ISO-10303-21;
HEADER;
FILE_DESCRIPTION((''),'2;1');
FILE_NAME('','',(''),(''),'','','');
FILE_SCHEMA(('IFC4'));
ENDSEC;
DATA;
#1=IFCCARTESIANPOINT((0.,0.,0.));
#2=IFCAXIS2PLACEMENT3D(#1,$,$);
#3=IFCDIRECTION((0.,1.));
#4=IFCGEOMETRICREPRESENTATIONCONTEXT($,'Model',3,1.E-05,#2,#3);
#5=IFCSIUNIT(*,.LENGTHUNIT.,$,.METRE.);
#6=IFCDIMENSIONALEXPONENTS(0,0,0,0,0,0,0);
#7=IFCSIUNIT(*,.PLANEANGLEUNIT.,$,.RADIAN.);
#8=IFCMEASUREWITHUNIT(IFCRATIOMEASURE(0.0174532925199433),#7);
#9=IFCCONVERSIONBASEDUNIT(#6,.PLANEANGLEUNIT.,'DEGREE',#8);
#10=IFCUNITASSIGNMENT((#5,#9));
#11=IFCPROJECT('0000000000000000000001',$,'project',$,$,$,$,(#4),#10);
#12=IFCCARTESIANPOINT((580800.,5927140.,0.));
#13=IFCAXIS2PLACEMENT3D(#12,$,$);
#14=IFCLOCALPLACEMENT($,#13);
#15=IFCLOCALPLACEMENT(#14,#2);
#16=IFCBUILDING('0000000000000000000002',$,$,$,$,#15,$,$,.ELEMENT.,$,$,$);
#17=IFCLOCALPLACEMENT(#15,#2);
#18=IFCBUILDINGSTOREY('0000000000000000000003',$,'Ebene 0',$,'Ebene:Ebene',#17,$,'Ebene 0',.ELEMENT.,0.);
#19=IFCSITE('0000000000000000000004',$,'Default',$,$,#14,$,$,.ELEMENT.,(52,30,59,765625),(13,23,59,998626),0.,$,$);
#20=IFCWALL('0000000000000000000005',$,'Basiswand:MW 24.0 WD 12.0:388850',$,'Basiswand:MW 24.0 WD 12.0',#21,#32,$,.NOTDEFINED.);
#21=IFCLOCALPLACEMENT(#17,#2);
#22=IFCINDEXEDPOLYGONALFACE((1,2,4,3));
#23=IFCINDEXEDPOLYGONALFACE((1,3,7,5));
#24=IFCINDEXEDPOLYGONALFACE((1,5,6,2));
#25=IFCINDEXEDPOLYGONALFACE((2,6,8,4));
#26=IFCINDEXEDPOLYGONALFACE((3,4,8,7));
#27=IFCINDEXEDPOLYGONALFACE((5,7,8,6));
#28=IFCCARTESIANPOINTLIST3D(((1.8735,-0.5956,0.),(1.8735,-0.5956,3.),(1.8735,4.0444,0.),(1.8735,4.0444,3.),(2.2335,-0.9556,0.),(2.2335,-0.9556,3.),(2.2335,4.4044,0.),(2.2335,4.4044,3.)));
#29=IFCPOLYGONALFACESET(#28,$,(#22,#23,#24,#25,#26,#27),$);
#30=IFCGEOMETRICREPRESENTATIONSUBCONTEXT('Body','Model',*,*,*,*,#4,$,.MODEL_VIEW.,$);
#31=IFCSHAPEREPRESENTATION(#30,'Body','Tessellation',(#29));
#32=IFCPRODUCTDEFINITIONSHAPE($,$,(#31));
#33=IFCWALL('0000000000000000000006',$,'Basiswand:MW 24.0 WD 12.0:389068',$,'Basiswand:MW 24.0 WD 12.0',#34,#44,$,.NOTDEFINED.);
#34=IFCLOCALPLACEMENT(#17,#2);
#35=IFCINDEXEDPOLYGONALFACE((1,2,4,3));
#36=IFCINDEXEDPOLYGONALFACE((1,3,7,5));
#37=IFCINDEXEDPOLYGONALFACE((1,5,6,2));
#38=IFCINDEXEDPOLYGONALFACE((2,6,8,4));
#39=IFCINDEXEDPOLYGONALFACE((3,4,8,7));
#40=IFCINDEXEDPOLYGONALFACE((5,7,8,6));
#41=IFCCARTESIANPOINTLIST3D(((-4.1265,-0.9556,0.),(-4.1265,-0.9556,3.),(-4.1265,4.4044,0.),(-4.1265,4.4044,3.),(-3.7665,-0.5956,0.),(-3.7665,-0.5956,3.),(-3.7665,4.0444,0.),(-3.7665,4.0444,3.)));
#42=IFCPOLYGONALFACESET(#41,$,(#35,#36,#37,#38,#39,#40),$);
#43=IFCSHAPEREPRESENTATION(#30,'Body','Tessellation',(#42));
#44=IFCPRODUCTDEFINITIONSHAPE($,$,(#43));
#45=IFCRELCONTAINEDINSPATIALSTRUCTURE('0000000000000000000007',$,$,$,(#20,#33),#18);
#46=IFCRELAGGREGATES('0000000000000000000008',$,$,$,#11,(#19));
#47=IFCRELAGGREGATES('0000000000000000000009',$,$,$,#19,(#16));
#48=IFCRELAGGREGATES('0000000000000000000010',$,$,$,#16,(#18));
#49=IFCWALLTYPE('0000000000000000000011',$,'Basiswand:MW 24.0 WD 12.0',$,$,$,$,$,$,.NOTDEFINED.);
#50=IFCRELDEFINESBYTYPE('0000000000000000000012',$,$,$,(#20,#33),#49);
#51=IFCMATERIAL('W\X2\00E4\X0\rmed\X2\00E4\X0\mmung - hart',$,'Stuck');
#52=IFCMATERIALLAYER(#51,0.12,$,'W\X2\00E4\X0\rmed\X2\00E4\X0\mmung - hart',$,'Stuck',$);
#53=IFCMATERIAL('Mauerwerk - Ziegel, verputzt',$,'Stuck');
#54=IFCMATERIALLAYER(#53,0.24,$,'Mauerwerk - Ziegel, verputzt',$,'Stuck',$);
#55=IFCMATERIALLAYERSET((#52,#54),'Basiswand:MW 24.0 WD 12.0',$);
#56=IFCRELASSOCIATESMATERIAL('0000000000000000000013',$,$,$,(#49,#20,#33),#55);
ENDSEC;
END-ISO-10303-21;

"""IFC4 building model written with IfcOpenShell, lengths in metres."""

from ifc_helpers import new_model, entity, si_unit, converted_unit, direction, frame, origin, place, context, subcontext, project, spatial, indexed_curve, outline, extrude, material, layer, layer_set, type_object, element, save


model = new_model("IFC4")

# Units and contexts
model_context = context("Model", 3, precision=1e-05, world=origin(), true_north=direction((0.0, 1.0)))
body_context = subcontext(model_context, "Body", "Model", "MODEL_VIEW")
ifc_project = project(units=[si_unit("LENGTHUNIT", "METRE"), converted_unit("PLANEANGLEUNIT", "DEGREE", entity("IfcRatioMeasure", 0.0174532925199433), si_unit("PLANEANGLEUNIT", "RADIAN"), dimensions=[0, 0, 0, 0, 0, 0, 0])], contexts=[model_context])

# Site, building, storey
site_placement = place(None, frame((580800.0, 5927140.0, 0.0)))
site = spatial("IfcSite", under=ifc_project, at=site_placement, Name="Default", CompositionType="ELEMENT", RefLatitude=(52, 30, 59, 765625), RefLongitude=(13, 23, 59, 998626), RefElevation=0.0)
building_placement = place(site_placement, origin())
building = spatial("IfcBuilding", under=site, at=building_placement, CompositionType="ELEMENT")
storey_placement = place(building_placement, origin())
storey = spatial("IfcBuildingStorey", under=building, at=storey_placement, Name="Ebene 0", ObjectType="Ebene:Ebene", LongName="Ebene 0", CompositionType="ELEMENT", Elevation=0.0)

# Walls
ifc_material_1 = material(Name="Wärmedämmung - hart", Category="Stuck")
ifc_layer_1 = layer(ifc_material_1, 0.12, Name="Wärmedämmung - hart", Category="Stuck")
ifc_material_2 = material(Name="Mauerwerk - Ziegel, verputzt", Category="Stuck")
ifc_layer_2 = layer(ifc_material_2, 0.24, Name="Mauerwerk - Ziegel, verputzt", Category="Stuck")
ifc_layer_set = layer_set([ifc_layer_1, ifc_layer_2], Name="Basiswand:MW 24.0 WD 12.0")
wall_type = type_object("IfcWallType", Name="Basiswand:MW 24.0 WD 12.0", PredefinedType="NOTDEFINED", material=ifc_layer_set)
wall_1_placement = place(storey_placement, frame((2.0535, 4.4044, 0.0), z_axis=(0.0, 0.0, 1.0), x_axis=(0.0, -1.0, 0.0)))
element("IfcWall", 1, at=wall_1_placement, inside=storey, type_object=wall_type, material=ifc_layer_set, Name="Basiswand:MW 24.0 WD 12.0:388850", ObjectType="Basiswand:MW 24.0 WD 12.0", PredefinedType="NOTDEFINED", context=body_context, shape_type="SweptSolid", body=[
    extrude(outline(indexed_curve([(5.0, -0.18), (5.36, 0.18), (0.0, 0.18), (0.36, -0.18), (5.0, -0.18)], self_intersect=False)), origin(), (0.0, 0.0, 1.0), 3.0),
])
wall_2_placement = place(storey_placement, frame((-3.9465, -0.9556, 0.0), z_axis=(0.0, 0.0, 1.0), x_axis=(0.0, 1.0, 0.0)))
element("IfcWall", 2, at=wall_2_placement, inside=storey, type_object=wall_type, material=ifc_layer_set, Name="Basiswand:MW 24.0 WD 12.0:389068", ObjectType="Basiswand:MW 24.0 WD 12.0", PredefinedType="NOTDEFINED", context=body_context, shape_type="SweptSolid", body=[
    extrude(outline(indexed_curve([(5.0, -0.18), (5.36, 0.18), (0.0, 0.18), (0.36, -0.18), (5.0, -0.18)], self_intersect=False)), origin(), (0.0, 0.0, 1.0), 3.0),
])

save(model, "model.ifc")
